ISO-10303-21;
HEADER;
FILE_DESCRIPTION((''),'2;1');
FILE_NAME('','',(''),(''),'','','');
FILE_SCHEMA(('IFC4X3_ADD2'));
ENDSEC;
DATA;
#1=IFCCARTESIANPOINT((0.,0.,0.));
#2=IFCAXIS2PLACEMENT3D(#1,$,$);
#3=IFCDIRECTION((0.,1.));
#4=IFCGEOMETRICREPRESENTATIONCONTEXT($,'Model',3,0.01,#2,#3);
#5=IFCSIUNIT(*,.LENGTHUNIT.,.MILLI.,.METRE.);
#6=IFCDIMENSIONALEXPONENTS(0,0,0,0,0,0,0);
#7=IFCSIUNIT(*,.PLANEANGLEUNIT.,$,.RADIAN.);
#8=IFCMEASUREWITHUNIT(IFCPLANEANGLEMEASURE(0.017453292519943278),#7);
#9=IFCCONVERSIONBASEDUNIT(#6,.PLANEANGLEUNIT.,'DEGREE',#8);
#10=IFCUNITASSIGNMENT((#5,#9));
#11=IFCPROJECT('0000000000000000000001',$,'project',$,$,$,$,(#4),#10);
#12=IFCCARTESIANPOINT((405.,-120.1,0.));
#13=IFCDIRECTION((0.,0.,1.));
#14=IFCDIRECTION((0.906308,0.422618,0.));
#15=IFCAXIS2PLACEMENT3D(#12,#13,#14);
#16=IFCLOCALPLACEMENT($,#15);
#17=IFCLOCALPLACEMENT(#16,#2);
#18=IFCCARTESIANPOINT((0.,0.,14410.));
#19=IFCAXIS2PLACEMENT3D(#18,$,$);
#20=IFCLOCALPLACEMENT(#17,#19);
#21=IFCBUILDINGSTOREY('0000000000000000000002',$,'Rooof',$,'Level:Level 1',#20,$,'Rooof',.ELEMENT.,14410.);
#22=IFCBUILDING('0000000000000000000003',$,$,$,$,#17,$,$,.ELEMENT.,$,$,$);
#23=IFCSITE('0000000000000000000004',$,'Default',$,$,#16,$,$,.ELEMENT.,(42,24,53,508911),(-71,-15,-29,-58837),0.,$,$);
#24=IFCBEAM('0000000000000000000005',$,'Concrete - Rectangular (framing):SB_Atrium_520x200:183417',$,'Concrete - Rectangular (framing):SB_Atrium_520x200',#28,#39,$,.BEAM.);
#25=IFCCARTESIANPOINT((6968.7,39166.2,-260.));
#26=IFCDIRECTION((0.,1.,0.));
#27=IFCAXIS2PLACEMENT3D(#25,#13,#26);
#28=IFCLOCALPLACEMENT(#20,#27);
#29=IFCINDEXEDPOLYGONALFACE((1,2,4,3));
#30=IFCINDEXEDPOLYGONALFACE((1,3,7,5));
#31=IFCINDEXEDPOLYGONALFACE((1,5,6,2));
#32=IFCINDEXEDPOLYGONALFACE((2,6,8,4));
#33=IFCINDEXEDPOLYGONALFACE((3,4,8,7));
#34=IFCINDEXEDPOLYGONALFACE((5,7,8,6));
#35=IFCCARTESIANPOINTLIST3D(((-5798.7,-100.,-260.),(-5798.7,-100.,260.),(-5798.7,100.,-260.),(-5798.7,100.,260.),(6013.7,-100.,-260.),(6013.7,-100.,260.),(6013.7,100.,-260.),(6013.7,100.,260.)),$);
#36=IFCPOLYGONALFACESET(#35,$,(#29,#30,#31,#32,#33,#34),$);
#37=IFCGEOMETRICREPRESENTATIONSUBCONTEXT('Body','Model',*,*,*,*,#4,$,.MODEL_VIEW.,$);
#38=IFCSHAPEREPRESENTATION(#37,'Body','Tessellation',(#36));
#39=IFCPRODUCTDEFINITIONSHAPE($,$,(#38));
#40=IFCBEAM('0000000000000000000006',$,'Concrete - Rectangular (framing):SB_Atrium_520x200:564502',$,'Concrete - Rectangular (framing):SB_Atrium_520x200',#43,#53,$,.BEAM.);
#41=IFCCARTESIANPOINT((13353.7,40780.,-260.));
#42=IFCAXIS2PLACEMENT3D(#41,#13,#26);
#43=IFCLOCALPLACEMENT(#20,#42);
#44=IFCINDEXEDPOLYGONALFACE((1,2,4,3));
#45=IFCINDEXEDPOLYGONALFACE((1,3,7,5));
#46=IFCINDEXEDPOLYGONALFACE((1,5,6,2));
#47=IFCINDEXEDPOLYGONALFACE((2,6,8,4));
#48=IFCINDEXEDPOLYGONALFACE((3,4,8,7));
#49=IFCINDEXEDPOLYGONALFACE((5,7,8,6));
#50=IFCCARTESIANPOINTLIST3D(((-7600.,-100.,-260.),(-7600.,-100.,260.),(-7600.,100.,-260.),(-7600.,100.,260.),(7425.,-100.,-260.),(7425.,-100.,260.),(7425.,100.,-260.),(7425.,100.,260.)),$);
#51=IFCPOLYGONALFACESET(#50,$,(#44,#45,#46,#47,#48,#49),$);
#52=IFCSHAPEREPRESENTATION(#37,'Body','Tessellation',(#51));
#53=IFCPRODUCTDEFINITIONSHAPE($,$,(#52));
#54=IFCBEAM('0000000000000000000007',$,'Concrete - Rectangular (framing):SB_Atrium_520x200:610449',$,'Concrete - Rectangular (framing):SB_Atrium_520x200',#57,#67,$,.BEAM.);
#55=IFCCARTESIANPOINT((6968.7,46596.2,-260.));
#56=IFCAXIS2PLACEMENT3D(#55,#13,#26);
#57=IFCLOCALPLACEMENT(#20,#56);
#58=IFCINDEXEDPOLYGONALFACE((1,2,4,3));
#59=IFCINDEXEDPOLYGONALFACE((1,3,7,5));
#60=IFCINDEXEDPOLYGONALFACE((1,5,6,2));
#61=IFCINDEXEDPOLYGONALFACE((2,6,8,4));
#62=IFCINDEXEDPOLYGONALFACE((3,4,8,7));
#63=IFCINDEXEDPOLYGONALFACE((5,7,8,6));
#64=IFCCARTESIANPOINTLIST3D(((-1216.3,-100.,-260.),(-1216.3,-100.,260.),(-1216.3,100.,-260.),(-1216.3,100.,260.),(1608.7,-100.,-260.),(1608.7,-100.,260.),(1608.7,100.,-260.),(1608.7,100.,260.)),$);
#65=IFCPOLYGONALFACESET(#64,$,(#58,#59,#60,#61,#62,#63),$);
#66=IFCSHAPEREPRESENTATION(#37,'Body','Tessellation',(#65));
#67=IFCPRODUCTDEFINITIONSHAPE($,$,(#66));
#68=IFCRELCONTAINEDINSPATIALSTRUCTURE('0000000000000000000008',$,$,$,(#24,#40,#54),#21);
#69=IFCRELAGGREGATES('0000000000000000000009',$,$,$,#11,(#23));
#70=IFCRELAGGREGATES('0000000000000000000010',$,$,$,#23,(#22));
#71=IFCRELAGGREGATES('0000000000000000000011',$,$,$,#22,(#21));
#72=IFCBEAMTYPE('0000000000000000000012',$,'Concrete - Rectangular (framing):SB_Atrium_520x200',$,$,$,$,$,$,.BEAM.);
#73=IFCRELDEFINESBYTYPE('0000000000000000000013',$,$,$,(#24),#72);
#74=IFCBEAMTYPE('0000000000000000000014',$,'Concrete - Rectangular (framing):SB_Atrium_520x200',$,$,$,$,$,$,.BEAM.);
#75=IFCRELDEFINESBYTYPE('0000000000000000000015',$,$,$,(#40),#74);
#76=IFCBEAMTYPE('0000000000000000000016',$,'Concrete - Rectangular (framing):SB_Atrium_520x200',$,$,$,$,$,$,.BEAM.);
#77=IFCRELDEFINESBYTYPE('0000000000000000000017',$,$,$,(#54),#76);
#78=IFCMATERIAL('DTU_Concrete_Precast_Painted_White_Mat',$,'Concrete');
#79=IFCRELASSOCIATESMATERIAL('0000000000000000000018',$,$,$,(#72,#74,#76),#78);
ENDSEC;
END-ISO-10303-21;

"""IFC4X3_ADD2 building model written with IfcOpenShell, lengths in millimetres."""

from ifc_helpers import new_model, entity, si_unit, converted_unit, direction, frame, origin, origin_2d_with_axis, place, context, subcontext, project, spatial, rectangle, extrude, source, transform, mapped, material, material_profile, profile_set, type_object, type_shapes, element, save


model = new_model("IFC4X3_ADD2")

# Units and contexts
model_context = context("Model", 3, precision=0.01, world=origin(), true_north=direction((0.0, 1.0)))
body_context = subcontext(model_context, "Body", "Model", "MODEL_VIEW")
ifc_project = project(units=[si_unit("LENGTHUNIT", "METRE", prefix="MILLI"), converted_unit("PLANEANGLEUNIT", "DEGREE", entity("IfcPlaneAngleMeasure", 0.017453292519943278), si_unit("PLANEANGLEUNIT", "RADIAN"), dimensions=[0, 0, 0, 0, 0, 0, 0])], contexts=[model_context])

# Site, building, storey
site_placement = place(None, frame((405.0, -120.1, 0.0), z_axis=(0.0, 0.0, 1.0), x_axis=(0.906308, 0.422618, 0.0)))
site = spatial("IfcSite", under=ifc_project, at=site_placement, Name="Default", CompositionType="ELEMENT", RefLatitude=(42, 24, 53, 508911), RefLongitude=(-71, -15, -29, -58837), RefElevation=0.0)
building_placement = place(site_placement, origin())
building = spatial("IfcBuilding", under=site, at=building_placement, CompositionType="ELEMENT")
storey_placement = place(building_placement, frame((0.0, 0.0, 14410.0)))
storey = spatial("IfcBuildingStorey", under=building, at=storey_placement, Name="Rooof", ObjectType="Level:Level 1", LongName="Rooof", CompositionType="ELEMENT", Elevation=14410.0)

# Beams
ifc_material_1 = material(Name="DTU_Concrete_Precast_Painted_White_Mat", Category="Concrete")
ifc_material_profile = material_profile(ifc_material_1, rectangle(XDim=13000.0, YDim=200.0, at=origin_2d_with_axis()), Name="SB_Atrium_520x200")
ifc_profile_set = profile_set([ifc_material_profile], Name="SB_Atrium_520x200")
beam_type_1 = type_object("IfcBeamType", Name="Concrete - Rectangular (framing):SB_Atrium_520x200", PredefinedType="BEAM", material=ifc_profile_set)
shared_shape_1 = source(origin(), body_context, "Body", "SweptSolid", [
    extrude(rectangle(XDim=11812.5, YDim=200.0, at=origin_2d_with_axis()), frame((107.5, 0.0, -260.0), z_axis=(0.0, 0.0, 1.0), x_axis=(-1.0, 0.0, 0.0)), (0.0, 0.0, 1.0), 520.0),
])
type_shapes(beam_type_1, [shared_shape_1])
beam_1_placement = place(storey_placement, frame((6968.7, 39166.2, -260.0), z_axis=(0.0, 0.0, 1.0), x_axis=(0.0, 1.0, 0.0)))
element("IfcBeam", 1, at=beam_1_placement, inside=storey, type_object=beam_type_1, Name="Concrete - Rectangular (framing):SB_Atrium_520x200:183417", ObjectType="Concrete - Rectangular (framing):SB_Atrium_520x200", PredefinedType="BEAM", context=body_context, shape_type="MappedRepresentation", body=[
    mapped(shared_shape_1, transform((0.0, 0.0, 0.0), scale=1.0)),
])
beam_type_2 = type_object("IfcBeamType", Name="Concrete - Rectangular (framing):SB_Atrium_520x200", PredefinedType="BEAM", material=ifc_profile_set)
shared_shape_2 = source(origin(), body_context, "Body", "SweptSolid", [
    extrude(rectangle(XDim=15025.0, YDim=200.0, at=origin_2d_with_axis()), frame((-87.5, 0.0, -260.0), z_axis=(0.0, 0.0, 1.0), x_axis=(-1.0, 0.0, 0.0)), (0.0, 0.0, 1.0), 520.0),
])
type_shapes(beam_type_2, [shared_shape_2])
beam_2_placement = place(storey_placement, frame((13353.7, 40780.0, -260.0), z_axis=(0.0, 0.0, 1.0), x_axis=(0.0, 1.0, 0.0)))
element("IfcBeam", 2, at=beam_2_placement, inside=storey, type_object=beam_type_2, Name="Concrete - Rectangular (framing):SB_Atrium_520x200:564502", ObjectType="Concrete - Rectangular (framing):SB_Atrium_520x200", PredefinedType="BEAM", context=body_context, shape_type="MappedRepresentation", body=[
    mapped(shared_shape_2, transform((0.0, 0.0, 0.0), scale=1.0)),
])
beam_type_3 = type_object("IfcBeamType", Name="Concrete - Rectangular (framing):SB_Atrium_520x200", PredefinedType="BEAM", material=ifc_profile_set)
shared_shape_3 = source(origin(), body_context, "Body", "SweptSolid", [
    extrude(rectangle(XDim=2825.0, YDim=200.0, at=origin_2d_with_axis()), frame((196.2, 0.0, -260.0), z_axis=(0.0, 0.0, 1.0), x_axis=(-1.0, 0.0, 0.0)), (0.0, 0.0, 1.0), 520.0),
])
type_shapes(beam_type_3, [shared_shape_3])
beam_3_placement = place(storey_placement, frame((6968.7, 46596.2, -260.0), z_axis=(0.0, 0.0, 1.0), x_axis=(0.0, 1.0, 0.0)))
element("IfcBeam", 3, at=beam_3_placement, inside=storey, type_object=beam_type_3, Name="Concrete - Rectangular (framing):SB_Atrium_520x200:610449", ObjectType="Concrete - Rectangular (framing):SB_Atrium_520x200", PredefinedType="BEAM", context=body_context, shape_type="MappedRepresentation", body=[
    mapped(shared_shape_3, transform((0.0, 0.0, 0.0), scale=1.0)),
])

save(model, "model.ifc")
